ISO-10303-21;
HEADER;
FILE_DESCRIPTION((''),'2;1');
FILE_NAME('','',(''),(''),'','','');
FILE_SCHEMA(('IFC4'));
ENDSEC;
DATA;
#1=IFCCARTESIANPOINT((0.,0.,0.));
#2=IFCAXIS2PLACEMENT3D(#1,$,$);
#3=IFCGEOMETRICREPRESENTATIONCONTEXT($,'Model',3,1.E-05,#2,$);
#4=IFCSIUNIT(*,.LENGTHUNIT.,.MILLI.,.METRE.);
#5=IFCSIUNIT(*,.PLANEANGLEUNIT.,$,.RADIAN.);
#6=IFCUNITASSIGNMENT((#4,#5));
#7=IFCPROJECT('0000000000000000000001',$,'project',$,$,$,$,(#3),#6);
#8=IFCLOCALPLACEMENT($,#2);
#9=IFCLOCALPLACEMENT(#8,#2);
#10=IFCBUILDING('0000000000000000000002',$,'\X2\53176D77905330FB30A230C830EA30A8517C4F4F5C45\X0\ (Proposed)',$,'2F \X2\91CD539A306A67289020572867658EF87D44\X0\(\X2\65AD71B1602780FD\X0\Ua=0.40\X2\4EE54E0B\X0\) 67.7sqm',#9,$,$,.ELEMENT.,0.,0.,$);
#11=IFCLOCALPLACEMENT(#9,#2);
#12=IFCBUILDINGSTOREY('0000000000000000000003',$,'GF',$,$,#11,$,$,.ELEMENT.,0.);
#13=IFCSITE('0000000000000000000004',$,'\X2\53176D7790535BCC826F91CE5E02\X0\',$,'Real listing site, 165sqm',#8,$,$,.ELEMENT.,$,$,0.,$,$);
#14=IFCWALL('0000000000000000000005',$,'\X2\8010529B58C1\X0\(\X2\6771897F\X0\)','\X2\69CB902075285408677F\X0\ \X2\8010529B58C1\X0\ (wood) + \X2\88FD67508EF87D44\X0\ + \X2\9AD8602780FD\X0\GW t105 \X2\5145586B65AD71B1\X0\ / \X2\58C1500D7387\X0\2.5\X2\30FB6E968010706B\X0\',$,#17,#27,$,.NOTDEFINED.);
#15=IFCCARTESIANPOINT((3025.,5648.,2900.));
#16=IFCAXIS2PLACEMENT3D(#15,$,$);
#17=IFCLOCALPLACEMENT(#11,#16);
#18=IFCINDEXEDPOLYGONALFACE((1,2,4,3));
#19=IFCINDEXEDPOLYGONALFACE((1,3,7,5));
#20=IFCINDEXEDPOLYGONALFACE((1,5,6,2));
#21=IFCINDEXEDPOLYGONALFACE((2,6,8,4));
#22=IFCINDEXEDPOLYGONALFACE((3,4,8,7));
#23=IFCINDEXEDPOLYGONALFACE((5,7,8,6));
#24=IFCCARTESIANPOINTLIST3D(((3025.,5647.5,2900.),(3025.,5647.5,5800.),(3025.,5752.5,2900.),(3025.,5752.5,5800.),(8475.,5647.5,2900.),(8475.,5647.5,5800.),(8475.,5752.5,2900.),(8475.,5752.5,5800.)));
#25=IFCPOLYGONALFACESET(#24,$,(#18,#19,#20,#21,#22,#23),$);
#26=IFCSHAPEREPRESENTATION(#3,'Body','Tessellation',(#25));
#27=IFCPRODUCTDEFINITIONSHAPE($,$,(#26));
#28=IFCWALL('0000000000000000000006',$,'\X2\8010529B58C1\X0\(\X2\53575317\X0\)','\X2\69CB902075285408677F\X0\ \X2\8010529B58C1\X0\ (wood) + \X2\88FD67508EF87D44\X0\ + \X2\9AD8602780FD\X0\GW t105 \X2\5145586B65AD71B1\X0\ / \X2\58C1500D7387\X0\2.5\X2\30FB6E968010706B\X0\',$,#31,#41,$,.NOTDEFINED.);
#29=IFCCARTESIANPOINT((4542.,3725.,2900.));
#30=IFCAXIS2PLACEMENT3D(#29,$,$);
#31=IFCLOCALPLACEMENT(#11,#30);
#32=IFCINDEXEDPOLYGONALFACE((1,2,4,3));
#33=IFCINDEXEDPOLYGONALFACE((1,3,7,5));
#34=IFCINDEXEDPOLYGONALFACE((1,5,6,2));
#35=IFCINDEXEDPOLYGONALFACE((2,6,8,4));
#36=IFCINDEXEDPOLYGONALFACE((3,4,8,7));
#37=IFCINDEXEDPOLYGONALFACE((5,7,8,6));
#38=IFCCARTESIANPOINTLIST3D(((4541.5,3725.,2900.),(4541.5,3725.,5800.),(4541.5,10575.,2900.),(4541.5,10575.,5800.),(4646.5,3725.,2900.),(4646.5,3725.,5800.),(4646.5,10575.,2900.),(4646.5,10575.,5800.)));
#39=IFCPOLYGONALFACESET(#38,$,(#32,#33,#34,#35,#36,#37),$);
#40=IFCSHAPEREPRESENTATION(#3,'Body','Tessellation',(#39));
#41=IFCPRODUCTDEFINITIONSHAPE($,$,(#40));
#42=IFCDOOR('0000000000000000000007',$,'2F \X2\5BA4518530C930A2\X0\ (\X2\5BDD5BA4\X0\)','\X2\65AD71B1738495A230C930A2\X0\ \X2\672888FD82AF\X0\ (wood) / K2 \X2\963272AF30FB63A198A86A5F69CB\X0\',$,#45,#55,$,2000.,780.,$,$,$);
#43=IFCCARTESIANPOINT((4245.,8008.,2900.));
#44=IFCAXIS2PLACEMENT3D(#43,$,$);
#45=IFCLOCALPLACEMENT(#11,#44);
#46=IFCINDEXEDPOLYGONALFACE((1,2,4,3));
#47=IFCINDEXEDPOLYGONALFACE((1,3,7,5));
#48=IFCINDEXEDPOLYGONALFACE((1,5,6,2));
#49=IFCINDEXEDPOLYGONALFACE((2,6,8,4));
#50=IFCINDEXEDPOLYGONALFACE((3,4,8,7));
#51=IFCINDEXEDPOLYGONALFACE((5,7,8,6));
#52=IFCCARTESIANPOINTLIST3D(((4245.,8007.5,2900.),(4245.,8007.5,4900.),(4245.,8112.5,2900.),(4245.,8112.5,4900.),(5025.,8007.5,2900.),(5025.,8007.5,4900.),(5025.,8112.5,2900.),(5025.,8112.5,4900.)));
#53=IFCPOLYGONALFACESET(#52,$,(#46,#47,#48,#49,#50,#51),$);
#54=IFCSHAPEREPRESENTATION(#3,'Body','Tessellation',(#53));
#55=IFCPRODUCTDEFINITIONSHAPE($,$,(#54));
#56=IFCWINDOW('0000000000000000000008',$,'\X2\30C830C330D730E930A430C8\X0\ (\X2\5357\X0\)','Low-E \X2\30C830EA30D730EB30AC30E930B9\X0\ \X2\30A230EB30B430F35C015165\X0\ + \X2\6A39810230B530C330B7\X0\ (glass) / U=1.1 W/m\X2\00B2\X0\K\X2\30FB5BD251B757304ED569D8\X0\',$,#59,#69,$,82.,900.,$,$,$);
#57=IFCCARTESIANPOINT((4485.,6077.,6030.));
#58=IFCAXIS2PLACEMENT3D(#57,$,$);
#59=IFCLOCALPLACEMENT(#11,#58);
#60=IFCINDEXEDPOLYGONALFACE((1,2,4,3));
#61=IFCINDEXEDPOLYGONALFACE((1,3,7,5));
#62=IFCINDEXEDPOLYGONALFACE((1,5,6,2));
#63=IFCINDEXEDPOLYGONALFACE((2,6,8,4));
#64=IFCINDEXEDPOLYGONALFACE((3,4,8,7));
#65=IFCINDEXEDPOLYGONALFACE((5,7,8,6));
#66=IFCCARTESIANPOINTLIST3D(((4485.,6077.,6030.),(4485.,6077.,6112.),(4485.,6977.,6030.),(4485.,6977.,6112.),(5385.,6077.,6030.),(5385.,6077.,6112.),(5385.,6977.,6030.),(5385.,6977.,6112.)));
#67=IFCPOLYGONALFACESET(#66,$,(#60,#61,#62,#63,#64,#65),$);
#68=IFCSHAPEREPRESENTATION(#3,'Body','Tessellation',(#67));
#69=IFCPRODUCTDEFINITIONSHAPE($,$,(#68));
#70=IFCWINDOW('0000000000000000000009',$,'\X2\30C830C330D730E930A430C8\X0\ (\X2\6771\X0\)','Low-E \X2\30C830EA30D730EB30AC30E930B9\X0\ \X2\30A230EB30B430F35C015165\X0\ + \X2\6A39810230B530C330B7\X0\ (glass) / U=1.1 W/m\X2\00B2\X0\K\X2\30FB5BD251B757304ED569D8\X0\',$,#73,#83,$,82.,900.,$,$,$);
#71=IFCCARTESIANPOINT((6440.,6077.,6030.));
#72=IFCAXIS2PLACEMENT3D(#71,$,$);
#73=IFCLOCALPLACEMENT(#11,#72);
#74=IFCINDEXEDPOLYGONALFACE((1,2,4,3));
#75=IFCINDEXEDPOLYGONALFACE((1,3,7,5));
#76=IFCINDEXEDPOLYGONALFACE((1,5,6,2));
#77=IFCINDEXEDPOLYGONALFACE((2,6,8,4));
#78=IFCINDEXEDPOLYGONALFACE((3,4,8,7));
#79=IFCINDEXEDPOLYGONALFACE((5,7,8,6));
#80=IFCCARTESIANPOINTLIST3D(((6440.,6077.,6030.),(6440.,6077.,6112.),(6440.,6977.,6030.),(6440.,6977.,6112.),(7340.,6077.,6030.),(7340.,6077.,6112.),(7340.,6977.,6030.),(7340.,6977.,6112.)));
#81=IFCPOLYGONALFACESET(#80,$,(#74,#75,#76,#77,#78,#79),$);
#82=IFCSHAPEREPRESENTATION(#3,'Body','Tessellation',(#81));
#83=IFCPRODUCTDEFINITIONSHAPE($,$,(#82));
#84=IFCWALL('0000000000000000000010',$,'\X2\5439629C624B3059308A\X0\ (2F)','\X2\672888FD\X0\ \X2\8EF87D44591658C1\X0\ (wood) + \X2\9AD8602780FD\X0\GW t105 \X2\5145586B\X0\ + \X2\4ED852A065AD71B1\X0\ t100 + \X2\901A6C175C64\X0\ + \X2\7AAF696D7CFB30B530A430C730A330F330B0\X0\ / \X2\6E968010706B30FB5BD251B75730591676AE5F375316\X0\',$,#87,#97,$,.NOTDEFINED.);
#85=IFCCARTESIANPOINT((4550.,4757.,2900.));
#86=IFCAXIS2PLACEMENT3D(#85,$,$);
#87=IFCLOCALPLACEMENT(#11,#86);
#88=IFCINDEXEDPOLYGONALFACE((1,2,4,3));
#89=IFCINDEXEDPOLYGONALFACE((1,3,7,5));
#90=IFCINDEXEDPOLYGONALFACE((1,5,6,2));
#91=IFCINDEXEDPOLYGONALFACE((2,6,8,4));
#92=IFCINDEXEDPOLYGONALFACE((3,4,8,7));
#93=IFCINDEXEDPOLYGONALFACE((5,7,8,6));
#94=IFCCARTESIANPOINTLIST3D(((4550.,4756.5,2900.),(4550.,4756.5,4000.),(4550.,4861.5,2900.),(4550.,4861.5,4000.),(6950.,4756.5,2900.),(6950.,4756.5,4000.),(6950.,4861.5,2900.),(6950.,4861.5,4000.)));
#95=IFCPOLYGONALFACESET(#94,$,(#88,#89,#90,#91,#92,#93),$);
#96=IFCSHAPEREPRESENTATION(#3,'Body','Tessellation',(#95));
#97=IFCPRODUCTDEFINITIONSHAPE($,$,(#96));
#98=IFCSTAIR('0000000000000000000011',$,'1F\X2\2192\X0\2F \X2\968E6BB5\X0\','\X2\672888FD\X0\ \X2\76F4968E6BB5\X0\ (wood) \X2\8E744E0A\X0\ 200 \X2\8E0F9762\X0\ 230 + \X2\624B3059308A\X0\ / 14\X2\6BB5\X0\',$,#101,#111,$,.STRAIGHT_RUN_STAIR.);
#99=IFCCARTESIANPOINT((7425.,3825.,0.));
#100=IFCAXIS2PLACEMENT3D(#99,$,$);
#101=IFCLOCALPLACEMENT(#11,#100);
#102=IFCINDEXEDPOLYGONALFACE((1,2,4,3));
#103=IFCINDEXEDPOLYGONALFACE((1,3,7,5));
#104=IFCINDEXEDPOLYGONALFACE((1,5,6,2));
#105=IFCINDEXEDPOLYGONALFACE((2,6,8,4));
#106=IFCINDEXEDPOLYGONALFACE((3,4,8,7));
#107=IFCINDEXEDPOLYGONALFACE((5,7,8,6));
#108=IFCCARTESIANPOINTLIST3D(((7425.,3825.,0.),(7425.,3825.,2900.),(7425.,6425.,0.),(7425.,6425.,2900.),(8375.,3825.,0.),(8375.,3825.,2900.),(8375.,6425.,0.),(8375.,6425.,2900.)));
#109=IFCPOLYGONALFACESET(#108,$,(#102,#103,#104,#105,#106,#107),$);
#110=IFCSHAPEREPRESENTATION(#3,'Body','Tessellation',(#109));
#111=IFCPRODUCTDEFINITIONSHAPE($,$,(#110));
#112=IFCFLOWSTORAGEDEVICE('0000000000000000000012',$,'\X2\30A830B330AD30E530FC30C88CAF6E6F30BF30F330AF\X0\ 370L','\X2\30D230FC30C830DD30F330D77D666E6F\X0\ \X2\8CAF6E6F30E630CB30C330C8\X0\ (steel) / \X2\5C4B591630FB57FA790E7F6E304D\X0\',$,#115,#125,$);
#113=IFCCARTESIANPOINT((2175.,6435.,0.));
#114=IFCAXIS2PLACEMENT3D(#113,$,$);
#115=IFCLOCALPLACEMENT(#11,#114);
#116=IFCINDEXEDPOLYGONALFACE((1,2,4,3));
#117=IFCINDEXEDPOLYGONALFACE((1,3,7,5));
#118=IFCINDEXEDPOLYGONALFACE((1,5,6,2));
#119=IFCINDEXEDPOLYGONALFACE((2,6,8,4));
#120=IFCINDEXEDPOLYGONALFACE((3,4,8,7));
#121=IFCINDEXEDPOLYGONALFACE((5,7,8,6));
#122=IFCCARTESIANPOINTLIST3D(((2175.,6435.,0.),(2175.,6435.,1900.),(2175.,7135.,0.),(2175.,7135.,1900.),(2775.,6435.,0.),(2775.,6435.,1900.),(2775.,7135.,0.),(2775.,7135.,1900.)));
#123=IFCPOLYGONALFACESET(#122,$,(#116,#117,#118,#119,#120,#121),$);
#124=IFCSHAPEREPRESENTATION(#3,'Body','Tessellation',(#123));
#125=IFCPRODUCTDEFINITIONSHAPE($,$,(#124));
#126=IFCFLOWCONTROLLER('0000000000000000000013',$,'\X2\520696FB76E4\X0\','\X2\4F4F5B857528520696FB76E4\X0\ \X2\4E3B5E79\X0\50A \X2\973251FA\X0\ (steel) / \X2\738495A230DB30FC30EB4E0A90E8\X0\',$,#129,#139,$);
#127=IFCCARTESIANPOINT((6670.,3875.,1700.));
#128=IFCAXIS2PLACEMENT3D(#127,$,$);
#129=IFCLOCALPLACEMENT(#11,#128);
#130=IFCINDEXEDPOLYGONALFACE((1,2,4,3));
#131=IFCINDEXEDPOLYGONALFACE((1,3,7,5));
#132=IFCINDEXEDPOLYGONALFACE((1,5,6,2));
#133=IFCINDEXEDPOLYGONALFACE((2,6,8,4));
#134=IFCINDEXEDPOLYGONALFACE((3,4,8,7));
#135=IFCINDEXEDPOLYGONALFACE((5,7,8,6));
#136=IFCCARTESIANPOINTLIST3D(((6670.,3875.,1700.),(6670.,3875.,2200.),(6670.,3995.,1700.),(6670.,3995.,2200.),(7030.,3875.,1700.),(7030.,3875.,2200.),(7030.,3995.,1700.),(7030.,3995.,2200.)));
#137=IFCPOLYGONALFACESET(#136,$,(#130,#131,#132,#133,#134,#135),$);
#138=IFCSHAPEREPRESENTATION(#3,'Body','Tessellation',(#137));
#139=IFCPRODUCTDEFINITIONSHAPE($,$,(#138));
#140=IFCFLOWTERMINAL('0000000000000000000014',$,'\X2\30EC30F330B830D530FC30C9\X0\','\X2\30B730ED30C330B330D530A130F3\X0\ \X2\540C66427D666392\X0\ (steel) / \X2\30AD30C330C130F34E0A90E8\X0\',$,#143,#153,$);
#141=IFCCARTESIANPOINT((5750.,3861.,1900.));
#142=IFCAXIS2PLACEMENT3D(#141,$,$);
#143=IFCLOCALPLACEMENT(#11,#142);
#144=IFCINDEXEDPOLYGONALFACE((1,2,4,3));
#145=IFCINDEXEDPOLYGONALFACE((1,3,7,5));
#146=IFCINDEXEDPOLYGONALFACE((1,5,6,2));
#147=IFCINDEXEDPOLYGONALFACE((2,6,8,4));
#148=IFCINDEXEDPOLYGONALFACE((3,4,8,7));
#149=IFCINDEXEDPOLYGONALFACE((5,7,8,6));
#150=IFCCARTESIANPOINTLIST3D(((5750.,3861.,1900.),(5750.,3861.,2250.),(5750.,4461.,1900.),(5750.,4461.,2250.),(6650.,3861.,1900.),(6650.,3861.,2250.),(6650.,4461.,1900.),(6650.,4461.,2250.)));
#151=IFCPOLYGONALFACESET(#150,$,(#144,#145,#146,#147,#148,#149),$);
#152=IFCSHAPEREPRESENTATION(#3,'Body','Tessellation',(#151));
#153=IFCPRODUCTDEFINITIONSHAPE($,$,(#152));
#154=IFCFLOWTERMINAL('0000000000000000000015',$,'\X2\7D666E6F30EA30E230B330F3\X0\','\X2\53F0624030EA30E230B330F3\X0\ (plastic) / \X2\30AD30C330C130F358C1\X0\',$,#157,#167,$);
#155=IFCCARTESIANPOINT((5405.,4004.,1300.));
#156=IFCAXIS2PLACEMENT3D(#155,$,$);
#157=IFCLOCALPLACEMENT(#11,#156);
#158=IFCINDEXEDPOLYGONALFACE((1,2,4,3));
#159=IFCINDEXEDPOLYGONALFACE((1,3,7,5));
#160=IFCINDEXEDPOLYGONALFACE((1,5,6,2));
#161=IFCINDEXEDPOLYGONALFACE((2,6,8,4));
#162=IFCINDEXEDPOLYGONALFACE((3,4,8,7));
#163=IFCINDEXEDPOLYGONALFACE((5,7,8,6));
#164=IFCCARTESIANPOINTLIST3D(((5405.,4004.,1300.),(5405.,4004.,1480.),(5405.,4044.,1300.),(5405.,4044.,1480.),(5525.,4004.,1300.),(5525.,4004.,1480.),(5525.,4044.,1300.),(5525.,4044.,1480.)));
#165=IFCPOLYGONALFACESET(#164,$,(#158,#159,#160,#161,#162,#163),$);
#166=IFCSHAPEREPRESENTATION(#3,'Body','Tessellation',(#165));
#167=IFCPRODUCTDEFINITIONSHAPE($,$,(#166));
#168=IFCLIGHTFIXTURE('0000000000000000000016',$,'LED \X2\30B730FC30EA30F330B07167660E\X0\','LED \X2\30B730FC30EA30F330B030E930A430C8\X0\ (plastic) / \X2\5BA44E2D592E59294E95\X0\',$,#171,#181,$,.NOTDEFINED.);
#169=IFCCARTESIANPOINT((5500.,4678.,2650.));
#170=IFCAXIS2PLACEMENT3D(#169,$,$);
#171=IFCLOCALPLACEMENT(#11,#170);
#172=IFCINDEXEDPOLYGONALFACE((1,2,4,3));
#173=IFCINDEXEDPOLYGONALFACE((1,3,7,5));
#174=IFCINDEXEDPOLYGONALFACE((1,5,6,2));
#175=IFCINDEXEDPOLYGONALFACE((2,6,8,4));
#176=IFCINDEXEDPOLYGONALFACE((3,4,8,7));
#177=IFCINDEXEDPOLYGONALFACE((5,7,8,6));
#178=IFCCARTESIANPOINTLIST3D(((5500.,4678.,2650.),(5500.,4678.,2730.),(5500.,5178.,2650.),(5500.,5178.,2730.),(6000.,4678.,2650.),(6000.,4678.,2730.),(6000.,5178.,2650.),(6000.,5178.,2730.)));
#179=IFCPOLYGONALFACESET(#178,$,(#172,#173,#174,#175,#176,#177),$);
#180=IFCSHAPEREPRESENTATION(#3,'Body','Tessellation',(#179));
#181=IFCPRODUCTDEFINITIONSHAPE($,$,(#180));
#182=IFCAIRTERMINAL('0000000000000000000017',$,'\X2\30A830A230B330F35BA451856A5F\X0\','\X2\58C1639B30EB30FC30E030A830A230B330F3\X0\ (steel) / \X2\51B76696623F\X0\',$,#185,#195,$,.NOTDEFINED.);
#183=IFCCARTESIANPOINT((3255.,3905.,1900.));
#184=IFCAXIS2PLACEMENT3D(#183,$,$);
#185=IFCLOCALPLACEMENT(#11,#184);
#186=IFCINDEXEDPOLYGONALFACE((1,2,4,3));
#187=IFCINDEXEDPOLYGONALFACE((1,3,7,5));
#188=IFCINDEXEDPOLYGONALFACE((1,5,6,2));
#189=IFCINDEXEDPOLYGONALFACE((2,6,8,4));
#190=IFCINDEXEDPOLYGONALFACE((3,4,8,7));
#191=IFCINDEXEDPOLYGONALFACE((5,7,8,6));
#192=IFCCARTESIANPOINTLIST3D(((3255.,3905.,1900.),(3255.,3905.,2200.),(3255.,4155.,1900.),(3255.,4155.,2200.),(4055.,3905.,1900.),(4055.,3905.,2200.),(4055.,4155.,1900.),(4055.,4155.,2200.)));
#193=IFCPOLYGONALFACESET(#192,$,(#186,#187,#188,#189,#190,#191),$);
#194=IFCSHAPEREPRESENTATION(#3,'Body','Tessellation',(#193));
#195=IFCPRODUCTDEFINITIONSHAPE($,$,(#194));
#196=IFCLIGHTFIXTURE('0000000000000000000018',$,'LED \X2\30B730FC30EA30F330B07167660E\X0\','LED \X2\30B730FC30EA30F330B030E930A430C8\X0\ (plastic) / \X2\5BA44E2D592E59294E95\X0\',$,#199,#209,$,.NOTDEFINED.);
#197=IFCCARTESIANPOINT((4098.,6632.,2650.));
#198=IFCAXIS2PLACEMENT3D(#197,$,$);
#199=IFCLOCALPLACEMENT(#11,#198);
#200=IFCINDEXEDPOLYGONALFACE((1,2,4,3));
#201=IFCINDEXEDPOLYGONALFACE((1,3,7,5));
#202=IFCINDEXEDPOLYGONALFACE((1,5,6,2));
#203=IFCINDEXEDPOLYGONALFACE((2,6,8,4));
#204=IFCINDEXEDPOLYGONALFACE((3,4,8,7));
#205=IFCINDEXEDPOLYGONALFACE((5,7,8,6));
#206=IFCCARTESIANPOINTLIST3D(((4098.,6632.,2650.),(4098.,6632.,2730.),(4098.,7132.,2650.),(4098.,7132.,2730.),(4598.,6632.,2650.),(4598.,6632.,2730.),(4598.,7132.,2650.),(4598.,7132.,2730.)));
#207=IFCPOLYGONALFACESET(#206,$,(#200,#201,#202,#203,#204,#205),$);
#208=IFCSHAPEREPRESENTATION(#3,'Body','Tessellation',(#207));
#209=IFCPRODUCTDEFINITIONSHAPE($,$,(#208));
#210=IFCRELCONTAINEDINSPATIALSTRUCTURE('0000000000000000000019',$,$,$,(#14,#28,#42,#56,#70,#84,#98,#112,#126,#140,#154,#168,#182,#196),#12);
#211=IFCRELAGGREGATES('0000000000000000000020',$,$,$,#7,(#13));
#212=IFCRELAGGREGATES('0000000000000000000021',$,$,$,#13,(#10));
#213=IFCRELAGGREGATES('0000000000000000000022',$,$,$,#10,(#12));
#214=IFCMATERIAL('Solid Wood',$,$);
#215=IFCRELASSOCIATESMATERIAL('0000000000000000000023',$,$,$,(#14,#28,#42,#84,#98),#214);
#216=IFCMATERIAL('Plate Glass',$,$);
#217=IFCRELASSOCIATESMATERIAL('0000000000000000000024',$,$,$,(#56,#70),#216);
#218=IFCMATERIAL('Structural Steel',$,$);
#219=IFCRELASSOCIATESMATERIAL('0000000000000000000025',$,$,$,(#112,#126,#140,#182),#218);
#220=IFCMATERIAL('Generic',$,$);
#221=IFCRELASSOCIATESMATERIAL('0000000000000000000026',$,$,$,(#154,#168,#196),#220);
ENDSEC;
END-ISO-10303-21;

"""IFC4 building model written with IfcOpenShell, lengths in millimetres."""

from ifc_helpers import new_model, si_unit, frame, frame_2d, origin, place, context, project, spatial, rectangle, extrude, material, element, fill, save


model = new_model("IFC4")

# Units and contexts
model_context = context("Model", 3, precision=1e-05, world=origin())
ifc_project = project(units=[si_unit("LENGTHUNIT", "METRE", prefix="MILLI"), si_unit("PLANEANGLEUNIT", "RADIAN")], contexts=[model_context])

# Site, building, storey
site_placement = place(None, origin())
site = spatial("IfcSite", under=ifc_project, at=site_placement, Name="北海道富良野市", ObjectType="Real listing site, 165sqm", CompositionType="ELEMENT", RefElevation=0.0)
building_placement = place(site_placement, origin())
building = spatial("IfcBuilding", under=site, at=building_placement, Name="北海道・アトリエ兼住居 (Proposed)", ObjectType="2F 重厚な木造在来軸組(断熱性能Ua=0.40以下) 67.7sqm", CompositionType="ELEMENT", ElevationOfRefHeight=0.0, ElevationOfTerrain=0.0)
storey_placement = place(building_placement, origin())
storey = spatial("IfcBuildingStorey", under=building, at=storey_placement, Name="GF", CompositionType="ELEMENT", Elevation=0.0)

# Shared definitions
ifc_material_1 = material(Name="Solid Wood")

# Wall
wall_1_placement = place(storey_placement, frame((3025.0, 5648.0, 2900.0)))
element("IfcWall", 1, at=wall_1_placement, inside=storey, material=ifc_material_1, Name="耐力壁(東西)", Description="構造用合板 耐力壁 (wood) + 製材軸組 + 高性能GW t105 充填断熱 / 壁倍率2.5・準耐火", PredefinedType="NOTDEFINED", context=model_context, shape_type="SweptSolid", body=[
    extrude(rectangle(XDim=5450.0, YDim=105.0, at=frame_2d((2725.0, 52.0))), frame((3025.0, 5648.0, 2900.0)), (0.0, 0.0, 1.0), 2900.0),
])

# Wall, opening, door
wall_2_placement = place(storey_placement, frame((4542.0, 3725.0, 2900.0)))
wall_2 = element("IfcWall", 2, at=wall_2_placement, inside=storey, material=ifc_material_1, Name="耐力壁(南北)", Description="構造用合板 耐力壁 (wood) + 製材軸組 + 高性能GW t105 充填断熱 / 壁倍率2.5・準耐火", PredefinedType="NOTDEFINED", context=model_context, shape_type="SweptSolid", body=[
    extrude(rectangle(XDim=105.0, YDim=6850.0, at=frame_2d((52.0, 3425.0))), frame((4542.0, 3725.0, 2900.0)), (0.0, 0.0, 1.0), 2900.0),
])
opening_placement = place(storey_placement, frame((4245.0, 8008.0, 2900.0)))
opening = element("IfcOpeningElement", 3, at=opening_placement, cuts=wall_2, PredefinedType="NOTDEFINED", context=model_context, shape_type="SweptSolid", body=[
    extrude(rectangle(XDim=780.0, YDim=105.0, at=frame_2d((390.0, 52.0))), frame((4245.0, 8008.0, 2900.0)), (0.0, 0.0, 1.0), 2000.0),
])
door_placement = place(storey_placement, frame((4245.0, 8008.0, 2900.0)))
door = element("IfcDoor", 4, at=door_placement, inside=storey, material=ifc_material_1, Name="2F 室内ドア (寝室)", Description="断熱玄関ドア 木製芯 (wood) / K2 防犯・採風機構", OverallHeight=2000.0, OverallWidth=780.0, context=model_context, shape_type="SweptSolid", body=[
    extrude(rectangle(XDim=780.0, YDim=105.0, at=frame_2d((390.0, 52.0))), frame((4245.0, 8008.0, 2900.0)), (0.0, 0.0, 1.0), 2000.0),
])
fill(opening, door)

# Windows
ifc_material_2 = material(Name="Plate Glass")
window_1_placement = place(storey_placement, frame((4485.0, 6077.0, 6030.0)))
element("IfcWindow", 5, at=window_1_placement, inside=storey, material=ifc_material_2, Name="トップライト (南)", Description="Low-E トリプルガラス アルゴン封入 + 樹脂サッシ (glass) / U=1.1 W/m²K・寒冷地仕様", OverallHeight=82.0, OverallWidth=900.0, context=model_context, shape_type="SweptSolid", body=[
    extrude(rectangle(XDim=900.0, YDim=900.0, at=frame_2d((450.0, 450.0))), frame((4485.0, 6077.0, 6030.0)), (0.0, 0.0, 1.0), 82.0),
])
window_2_placement = place(storey_placement, frame((6440.0, 6077.0, 6030.0)))
element("IfcWindow", 6, at=window_2_placement, inside=storey, material=ifc_material_2, Name="トップライト (東)", Description="Low-E トリプルガラス アルゴン封入 + 樹脂サッシ (glass) / U=1.1 W/m²K・寒冷地仕様", OverallHeight=82.0, OverallWidth=900.0, context=model_context, shape_type="SweptSolid", body=[
    extrude(rectangle(XDim=900.0, YDim=900.0, at=frame_2d((450.0, 450.0))), frame((6440.0, 6077.0, 6030.0)), (0.0, 0.0, 1.0), 82.0),
])

# Wall
wall_3_placement = place(storey_placement, frame((4550.0, 4757.0, 2900.0)))
element("IfcWall", 7, at=wall_3_placement, inside=storey, material=ifc_material_1, Name="吹抜手すり (2F)", Description="木製 軸組外壁 (wood) + 高性能GW t105 充填 + 付加断熱 t100 + 通気層 + 窯業系サイディング / 準耐火・寒冷地外皮強化", PredefinedType="NOTDEFINED", context=model_context, shape_type="SweptSolid", body=[
    extrude(rectangle(XDim=2400.0, YDim=105.0, at=frame_2d((1200.0, 52.0))), frame((4550.0, 4757.0, 2900.0)), (0.0, 0.0, 1.0), 1100.0),
])

# Stair
stair_placement = place(storey_placement, frame((7425.0, 3825.0, 0.0)))
element("IfcStair", 8, at=stair_placement, inside=storey, material=ifc_material_1, Name="1F→2F 階段", Description="木製 直階段 (wood) 蹴上 200 踏面 230 + 手すり / 14段", PredefinedType="STRAIGHT_RUN_STAIR", context=model_context, shape_type="SweptSolid", body=[
    extrude(rectangle(XDim=950.0, YDim=2600.0, at=frame_2d((475.0, 1300.0))), frame((7425.0, 3825.0, 0.0)), (0.0, 0.0, 1.0), 2900.0),
])

# Flow storage device
ifc_material_3 = material(Name="Structural Steel")
flow_storage_device_placement = place(storey_placement, frame((2175.0, 6435.0, 0.0)))
element("IfcFlowStorageDevice", 9, at=flow_storage_device_placement, inside=storey, material=ifc_material_3, Name="エコキュート貯湯タンク 370L", Description="ヒートポンプ給湯 貯湯ユニット (steel) / 屋外・基礎置き", context=model_context, shape_type="SweptSolid", body=[
    extrude(rectangle(XDim=600.0, YDim=700.0, at=frame_2d((300.0, 350.0))), frame((2175.0, 6435.0, 0.0)), (0.0, 0.0, 1.0), 1900.0),
])

# Flow controller
flow_controller_placement = place(storey_placement, frame((6670.0, 3875.0, 1700.0)))
element("IfcFlowController", 10, at=flow_controller_placement, inside=storey, material=ifc_material_3, Name="分電盤", Description="住宅用分電盤 主幹50A 露出 (steel) / 玄関ホール上部", context=model_context, shape_type="SweptSolid", body=[
    extrude(rectangle(XDim=360.0, YDim=120.0, at=frame_2d((180.0, 60.0))), frame((6670.0, 3875.0, 1700.0)), (0.0, 0.0, 1.0), 500.0),
])

# Flow terminals
flow_terminal_1_placement = place(storey_placement, frame((5750.0, 3861.0, 1900.0)))
element("IfcFlowTerminal", 11, at=flow_terminal_1_placement, inside=storey, material=ifc_material_3, Name="レンジフード", Description="シロッコファン 同時給排 (steel) / キッチン上部", context=model_context, shape_type="SweptSolid", body=[
    extrude(rectangle(XDim=900.0, YDim=600.0, at=frame_2d((450.0, 300.0))), frame((5750.0, 3861.0, 1900.0)), (0.0, 0.0, 1.0), 350.0),
])
ifc_material_4 = material(Name="Generic")
flow_terminal_2_placement = place(storey_placement, frame((5405.0, 4004.0, 1300.0)))
element("IfcFlowTerminal", 12, at=flow_terminal_2_placement, inside=storey, material=ifc_material_4, Name="給湯リモコン", Description="台所リモコン (plastic) / キッチン壁", context=model_context, shape_type="SweptSolid", body=[
    extrude(rectangle(XDim=120.0, YDim=40.0, at=frame_2d((60.0, 20.0))), frame((5405.0, 4004.0, 1300.0)), (0.0, 0.0, 1.0), 180.0),
])

# Light fixture
light_fixture_1_placement = place(storey_placement, frame((5500.0, 4678.0, 2650.0)))
element("IfcLightFixture", 13, at=light_fixture_1_placement, inside=storey, material=ifc_material_4, Name="LED シーリング照明", Description="LED シーリングライト (plastic) / 室中央天井", PredefinedType="NOTDEFINED", context=model_context, shape_type="SweptSolid", body=[
    extrude(rectangle(XDim=500.0, YDim=500.0, at=frame_2d((250.0, 250.0))), frame((5500.0, 4678.0, 2650.0)), (0.0, 0.0, 1.0), 80.0),
])

# Air terminal
air_terminal_1_placement = place(storey_placement, frame((3255.0, 3905.0, 1900.0)))
element("IfcAirTerminal", 14, at=air_terminal_1_placement, inside=storey, material=ifc_material_3, Name="エアコン室内機", Description="壁掛ルームエアコン (steel) / 冷暖房", PredefinedType="NOTDEFINED", context=model_context, shape_type="SweptSolid", body=[
    extrude(rectangle(XDim=800.0, YDim=250.0, at=frame_2d((400.0, 125.0))), frame((3255.0, 3905.0, 1900.0)), (0.0, 0.0, 1.0), 300.0),
])

# Light fixture
light_fixture_2_placement = place(storey_placement, frame((4098.0, 6632.0, 2650.0)))
element("IfcLightFixture", 15, at=light_fixture_2_placement, inside=storey, material=ifc_material_4, Name="LED シーリング照明", Description="LED シーリングライト (plastic) / 室中央天井", PredefinedType="NOTDEFINED", context=model_context, shape_type="SweptSolid", body=[
    extrude(rectangle(XDim=500.0, YDim=500.0, at=frame_2d((250.0, 250.0))), frame((4098.0, 6632.0, 2650.0)), (0.0, 0.0, 1.0), 80.0),
])

save(model, "model.ifc")
